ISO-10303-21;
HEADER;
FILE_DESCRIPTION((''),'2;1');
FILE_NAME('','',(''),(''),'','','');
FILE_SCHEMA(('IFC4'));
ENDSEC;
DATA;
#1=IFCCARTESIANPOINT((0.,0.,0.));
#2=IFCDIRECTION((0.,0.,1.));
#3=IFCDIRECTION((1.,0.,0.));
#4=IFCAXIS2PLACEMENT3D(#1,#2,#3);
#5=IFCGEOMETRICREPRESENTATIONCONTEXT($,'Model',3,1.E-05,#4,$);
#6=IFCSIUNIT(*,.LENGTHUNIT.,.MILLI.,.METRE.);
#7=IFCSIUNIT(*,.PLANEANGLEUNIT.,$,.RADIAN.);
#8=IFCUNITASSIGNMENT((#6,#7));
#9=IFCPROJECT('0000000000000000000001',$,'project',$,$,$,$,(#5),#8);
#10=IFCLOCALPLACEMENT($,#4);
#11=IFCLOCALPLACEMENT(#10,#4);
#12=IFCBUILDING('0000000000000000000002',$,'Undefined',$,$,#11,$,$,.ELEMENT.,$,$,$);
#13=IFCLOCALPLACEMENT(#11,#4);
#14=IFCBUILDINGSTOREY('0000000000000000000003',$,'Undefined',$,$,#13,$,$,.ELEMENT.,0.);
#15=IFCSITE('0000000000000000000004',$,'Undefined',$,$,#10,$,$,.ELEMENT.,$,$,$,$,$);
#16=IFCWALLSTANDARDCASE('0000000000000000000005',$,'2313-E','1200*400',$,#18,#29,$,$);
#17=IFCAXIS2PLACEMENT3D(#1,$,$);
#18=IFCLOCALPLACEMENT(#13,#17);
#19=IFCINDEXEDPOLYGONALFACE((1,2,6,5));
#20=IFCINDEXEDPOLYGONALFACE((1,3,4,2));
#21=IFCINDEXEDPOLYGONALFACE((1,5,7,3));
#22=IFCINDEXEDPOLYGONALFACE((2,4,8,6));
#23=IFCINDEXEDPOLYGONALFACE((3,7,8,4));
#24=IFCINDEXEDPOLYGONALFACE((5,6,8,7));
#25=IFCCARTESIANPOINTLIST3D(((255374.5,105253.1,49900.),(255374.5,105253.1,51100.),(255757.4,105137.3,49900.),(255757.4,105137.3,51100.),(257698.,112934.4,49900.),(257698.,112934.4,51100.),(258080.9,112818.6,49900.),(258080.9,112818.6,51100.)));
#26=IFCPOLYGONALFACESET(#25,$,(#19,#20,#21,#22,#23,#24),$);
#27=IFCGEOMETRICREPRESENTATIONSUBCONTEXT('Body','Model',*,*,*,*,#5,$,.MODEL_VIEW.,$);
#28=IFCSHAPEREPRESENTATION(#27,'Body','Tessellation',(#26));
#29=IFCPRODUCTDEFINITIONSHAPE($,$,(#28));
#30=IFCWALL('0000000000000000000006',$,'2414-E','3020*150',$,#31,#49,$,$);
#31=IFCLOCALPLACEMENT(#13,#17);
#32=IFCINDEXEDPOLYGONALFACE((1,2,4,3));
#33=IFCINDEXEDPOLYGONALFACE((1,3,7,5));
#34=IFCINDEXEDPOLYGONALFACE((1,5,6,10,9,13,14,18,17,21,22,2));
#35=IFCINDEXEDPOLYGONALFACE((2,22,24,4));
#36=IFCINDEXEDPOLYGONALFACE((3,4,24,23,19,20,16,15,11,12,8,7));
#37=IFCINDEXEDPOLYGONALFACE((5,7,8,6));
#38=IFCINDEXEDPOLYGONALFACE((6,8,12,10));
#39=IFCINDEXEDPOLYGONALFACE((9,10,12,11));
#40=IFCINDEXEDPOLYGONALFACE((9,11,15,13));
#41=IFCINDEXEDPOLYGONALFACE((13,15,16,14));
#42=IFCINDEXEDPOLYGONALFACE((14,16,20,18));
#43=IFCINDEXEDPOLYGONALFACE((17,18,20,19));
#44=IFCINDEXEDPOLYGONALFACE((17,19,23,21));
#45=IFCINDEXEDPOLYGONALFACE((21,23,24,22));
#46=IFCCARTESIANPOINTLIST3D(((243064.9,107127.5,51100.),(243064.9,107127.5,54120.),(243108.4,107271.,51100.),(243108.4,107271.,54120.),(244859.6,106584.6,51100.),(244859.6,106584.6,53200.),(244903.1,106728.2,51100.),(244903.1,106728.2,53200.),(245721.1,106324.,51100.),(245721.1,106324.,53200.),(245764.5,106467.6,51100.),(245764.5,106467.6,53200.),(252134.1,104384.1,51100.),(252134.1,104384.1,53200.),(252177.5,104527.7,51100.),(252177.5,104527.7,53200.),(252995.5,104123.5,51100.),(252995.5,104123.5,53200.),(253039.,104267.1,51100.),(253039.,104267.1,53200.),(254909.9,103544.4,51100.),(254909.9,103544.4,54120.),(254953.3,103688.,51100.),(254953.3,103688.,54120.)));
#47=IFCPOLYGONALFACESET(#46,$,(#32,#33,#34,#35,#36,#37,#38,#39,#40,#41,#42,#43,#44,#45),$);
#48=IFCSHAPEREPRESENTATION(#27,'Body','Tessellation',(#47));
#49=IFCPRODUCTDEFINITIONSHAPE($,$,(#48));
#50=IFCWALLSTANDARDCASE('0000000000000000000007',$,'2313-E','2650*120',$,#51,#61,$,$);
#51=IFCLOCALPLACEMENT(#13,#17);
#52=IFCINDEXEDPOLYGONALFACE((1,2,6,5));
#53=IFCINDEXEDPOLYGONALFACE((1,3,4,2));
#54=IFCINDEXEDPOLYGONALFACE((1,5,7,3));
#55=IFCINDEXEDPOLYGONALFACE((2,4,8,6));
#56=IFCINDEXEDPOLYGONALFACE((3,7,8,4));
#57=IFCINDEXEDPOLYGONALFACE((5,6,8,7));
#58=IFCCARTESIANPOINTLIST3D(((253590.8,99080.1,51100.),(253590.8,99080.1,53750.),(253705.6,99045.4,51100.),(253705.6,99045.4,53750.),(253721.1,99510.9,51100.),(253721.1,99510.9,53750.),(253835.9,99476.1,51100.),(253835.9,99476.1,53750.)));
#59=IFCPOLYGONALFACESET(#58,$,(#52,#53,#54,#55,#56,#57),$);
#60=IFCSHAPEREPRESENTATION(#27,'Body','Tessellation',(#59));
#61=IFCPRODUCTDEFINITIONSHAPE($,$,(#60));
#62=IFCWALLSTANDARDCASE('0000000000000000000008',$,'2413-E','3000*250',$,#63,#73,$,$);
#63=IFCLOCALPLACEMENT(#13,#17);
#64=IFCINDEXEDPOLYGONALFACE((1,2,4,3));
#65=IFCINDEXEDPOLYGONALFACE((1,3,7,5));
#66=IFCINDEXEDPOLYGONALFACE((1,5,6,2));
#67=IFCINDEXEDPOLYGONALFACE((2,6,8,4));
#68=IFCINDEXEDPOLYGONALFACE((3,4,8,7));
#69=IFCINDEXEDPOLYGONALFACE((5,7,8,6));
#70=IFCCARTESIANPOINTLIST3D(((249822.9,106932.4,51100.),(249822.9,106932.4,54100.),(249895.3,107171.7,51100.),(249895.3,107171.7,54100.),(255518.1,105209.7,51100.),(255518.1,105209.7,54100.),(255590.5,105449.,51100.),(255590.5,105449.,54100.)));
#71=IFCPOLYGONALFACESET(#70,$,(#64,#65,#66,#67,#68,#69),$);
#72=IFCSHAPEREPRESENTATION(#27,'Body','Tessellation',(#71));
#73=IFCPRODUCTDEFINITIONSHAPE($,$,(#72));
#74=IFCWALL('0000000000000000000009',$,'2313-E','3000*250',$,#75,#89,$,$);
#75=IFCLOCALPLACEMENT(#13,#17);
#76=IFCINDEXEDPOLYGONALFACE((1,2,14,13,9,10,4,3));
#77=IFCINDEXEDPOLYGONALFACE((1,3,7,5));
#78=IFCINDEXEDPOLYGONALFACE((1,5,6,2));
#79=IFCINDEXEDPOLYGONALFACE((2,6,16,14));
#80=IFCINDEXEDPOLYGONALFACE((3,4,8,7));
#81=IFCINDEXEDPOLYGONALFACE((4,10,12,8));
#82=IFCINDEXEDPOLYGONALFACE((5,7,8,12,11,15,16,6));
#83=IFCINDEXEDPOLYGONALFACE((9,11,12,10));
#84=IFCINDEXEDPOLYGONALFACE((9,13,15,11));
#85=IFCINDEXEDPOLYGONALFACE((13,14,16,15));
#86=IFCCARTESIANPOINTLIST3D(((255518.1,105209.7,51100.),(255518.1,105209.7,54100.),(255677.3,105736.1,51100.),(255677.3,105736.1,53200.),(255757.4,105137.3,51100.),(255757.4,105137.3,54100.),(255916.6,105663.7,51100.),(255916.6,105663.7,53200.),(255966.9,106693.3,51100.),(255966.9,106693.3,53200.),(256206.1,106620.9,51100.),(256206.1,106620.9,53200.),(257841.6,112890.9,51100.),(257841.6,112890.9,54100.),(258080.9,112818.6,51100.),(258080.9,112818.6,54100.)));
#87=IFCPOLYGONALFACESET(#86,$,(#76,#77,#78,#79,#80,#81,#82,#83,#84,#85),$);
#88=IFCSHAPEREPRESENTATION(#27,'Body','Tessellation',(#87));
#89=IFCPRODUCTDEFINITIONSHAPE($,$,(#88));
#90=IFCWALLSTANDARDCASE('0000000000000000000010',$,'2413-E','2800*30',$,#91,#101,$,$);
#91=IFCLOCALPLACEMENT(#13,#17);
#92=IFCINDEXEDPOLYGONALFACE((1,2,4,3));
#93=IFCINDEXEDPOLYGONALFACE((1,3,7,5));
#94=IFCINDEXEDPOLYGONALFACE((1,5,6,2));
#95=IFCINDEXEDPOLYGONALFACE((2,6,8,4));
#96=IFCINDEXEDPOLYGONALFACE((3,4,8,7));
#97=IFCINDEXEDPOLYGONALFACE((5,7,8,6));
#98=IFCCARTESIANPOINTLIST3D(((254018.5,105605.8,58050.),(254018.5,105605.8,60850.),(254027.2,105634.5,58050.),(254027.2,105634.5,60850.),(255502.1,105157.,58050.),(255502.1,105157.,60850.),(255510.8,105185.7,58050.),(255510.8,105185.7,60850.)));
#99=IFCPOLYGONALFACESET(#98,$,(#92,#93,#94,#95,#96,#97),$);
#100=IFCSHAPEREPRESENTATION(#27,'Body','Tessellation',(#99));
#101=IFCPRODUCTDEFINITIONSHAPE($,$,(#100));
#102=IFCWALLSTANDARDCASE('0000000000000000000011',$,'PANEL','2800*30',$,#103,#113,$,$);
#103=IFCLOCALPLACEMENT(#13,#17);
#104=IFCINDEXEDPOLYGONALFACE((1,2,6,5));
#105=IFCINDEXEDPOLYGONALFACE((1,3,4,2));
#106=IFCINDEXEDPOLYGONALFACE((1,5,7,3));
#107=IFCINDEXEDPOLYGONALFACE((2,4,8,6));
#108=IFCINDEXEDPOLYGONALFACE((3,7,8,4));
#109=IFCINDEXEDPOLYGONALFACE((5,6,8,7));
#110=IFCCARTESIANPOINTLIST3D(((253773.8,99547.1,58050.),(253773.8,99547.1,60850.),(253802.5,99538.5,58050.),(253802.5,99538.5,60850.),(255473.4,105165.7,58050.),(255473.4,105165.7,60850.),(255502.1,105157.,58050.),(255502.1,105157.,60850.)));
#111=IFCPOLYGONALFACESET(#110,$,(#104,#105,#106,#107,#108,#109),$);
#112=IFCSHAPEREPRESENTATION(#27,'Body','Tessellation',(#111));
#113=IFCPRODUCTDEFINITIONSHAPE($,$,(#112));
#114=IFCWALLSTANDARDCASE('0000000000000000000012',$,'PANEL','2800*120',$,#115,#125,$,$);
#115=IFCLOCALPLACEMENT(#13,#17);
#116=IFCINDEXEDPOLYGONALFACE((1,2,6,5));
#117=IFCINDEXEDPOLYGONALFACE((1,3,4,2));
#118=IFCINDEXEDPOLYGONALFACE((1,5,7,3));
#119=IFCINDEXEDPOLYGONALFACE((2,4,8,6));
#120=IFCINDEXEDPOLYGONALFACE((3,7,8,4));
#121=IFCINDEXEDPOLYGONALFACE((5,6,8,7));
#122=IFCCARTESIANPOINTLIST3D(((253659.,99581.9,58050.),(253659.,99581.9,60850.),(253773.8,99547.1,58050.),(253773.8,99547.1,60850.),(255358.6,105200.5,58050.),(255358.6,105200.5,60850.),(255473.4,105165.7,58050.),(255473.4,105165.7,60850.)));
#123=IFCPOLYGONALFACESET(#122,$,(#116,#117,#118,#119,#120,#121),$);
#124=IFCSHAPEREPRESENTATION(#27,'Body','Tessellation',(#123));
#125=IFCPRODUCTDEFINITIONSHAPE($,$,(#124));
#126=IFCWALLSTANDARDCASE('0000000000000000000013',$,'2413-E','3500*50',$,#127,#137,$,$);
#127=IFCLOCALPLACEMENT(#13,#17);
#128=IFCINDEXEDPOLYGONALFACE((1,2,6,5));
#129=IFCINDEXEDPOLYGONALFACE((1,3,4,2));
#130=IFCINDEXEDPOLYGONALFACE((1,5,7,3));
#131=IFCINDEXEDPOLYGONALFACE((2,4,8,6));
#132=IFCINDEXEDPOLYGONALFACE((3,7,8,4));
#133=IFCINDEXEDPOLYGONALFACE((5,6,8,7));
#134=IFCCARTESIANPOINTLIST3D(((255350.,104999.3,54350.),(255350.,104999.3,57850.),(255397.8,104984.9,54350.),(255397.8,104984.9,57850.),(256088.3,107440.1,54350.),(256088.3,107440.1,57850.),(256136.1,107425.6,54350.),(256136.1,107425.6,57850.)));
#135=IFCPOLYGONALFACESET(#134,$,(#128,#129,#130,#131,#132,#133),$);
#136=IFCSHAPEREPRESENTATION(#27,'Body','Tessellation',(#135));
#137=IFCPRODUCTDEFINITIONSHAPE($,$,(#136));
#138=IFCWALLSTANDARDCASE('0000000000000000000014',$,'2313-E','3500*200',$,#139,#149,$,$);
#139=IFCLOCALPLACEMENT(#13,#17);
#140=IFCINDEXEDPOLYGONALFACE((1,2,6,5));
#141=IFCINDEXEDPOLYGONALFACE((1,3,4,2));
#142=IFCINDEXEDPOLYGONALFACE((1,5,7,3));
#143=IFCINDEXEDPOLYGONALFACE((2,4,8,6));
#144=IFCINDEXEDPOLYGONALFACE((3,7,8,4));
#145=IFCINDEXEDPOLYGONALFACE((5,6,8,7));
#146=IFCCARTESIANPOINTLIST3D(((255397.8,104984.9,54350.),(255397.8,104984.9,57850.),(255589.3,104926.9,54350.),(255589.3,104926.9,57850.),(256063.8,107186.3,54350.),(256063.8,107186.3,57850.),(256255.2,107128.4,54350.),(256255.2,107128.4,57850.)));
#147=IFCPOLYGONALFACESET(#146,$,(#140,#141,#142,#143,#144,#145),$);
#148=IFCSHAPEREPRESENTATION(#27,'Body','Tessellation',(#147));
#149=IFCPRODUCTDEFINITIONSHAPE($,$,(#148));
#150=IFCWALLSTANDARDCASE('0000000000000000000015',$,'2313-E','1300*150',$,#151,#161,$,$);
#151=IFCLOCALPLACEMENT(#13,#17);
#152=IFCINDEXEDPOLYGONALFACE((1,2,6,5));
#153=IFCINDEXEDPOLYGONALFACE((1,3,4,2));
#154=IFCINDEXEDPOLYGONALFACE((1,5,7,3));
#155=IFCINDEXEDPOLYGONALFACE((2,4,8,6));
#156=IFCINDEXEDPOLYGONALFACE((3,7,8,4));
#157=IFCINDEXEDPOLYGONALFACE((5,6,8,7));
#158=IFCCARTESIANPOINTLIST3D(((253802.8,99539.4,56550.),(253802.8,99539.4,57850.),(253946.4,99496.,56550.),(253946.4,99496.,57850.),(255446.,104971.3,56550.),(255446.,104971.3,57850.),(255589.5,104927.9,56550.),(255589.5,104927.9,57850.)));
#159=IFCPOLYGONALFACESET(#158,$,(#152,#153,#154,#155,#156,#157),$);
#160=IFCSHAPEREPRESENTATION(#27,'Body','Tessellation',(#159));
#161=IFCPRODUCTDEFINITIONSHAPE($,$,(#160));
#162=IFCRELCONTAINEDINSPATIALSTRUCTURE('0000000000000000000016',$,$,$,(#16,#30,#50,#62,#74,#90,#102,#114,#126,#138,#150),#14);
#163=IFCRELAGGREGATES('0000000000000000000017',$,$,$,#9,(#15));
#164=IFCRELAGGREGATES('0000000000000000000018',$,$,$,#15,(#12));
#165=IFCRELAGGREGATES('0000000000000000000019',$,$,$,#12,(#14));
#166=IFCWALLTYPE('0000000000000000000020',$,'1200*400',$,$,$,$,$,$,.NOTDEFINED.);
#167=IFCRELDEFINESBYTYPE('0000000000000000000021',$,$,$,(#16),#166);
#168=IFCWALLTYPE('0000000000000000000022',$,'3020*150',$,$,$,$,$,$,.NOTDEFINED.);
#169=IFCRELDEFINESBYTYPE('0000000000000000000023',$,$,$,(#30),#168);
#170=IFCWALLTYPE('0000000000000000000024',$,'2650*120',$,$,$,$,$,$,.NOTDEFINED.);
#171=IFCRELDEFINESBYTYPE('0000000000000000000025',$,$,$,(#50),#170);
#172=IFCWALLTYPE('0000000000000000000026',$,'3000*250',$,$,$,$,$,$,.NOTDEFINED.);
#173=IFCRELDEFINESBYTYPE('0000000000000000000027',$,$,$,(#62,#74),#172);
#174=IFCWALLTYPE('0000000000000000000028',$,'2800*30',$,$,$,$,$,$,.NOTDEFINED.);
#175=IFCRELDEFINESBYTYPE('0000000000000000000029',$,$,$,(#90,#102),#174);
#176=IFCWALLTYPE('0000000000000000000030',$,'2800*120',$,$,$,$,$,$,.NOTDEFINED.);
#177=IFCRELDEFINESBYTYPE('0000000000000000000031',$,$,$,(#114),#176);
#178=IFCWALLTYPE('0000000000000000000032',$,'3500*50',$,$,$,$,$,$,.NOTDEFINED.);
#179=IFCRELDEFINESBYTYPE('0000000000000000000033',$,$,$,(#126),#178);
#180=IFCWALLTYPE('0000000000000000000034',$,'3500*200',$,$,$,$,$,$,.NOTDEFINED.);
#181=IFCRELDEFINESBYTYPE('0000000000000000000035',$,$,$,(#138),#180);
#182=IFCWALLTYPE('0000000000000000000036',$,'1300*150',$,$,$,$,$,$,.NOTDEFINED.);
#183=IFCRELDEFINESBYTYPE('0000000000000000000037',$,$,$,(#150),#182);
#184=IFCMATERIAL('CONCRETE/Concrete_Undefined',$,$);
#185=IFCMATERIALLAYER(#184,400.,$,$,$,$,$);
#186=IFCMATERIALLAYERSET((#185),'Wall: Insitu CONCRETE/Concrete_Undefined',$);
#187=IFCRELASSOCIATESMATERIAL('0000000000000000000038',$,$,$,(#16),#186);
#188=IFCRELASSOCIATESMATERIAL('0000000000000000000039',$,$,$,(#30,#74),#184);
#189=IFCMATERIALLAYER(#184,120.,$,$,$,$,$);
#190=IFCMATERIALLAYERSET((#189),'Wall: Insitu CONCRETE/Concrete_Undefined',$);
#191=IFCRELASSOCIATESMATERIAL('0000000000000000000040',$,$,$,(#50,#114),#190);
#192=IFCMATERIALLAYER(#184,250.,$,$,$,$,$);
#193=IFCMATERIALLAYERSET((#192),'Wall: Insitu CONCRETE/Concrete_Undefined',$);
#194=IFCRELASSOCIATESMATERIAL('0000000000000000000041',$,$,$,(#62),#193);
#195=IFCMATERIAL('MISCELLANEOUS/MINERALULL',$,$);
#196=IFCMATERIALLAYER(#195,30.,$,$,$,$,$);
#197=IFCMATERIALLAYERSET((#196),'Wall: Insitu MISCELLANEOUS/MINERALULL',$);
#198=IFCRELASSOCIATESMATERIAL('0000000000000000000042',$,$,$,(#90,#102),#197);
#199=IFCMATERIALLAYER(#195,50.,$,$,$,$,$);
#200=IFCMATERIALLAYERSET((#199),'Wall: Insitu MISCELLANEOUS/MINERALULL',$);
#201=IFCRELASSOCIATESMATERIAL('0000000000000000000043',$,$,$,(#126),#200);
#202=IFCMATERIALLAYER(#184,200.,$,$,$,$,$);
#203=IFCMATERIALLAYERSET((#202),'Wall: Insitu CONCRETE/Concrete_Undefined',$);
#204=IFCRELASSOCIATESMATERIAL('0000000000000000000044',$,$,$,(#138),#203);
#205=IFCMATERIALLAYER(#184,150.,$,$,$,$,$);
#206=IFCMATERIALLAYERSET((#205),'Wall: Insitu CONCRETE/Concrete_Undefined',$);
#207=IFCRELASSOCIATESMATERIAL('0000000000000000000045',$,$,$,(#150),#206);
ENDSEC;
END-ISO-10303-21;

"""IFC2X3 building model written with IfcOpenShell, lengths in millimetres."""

from ifc_helpers import new_model, si_unit, frame, frame_2d, origin_with_axes, place, context, subcontext, project, spatial, rectangle, extrude, boolean, material, layer, layer_set, layer_usage, type_object, element, save


model = new_model("IFC2X3")

# Units and contexts
model_context = context("Model", 3, precision=1e-05, world=origin_with_axes())
body_context = subcontext(model_context, "Body", "Model", "MODEL_VIEW")
ifc_project = project(units=[si_unit("LENGTHUNIT", "METRE", prefix="MILLI"), si_unit("PLANEANGLEUNIT", "RADIAN")], contexts=[model_context])

# Site, building, storey
site_placement = place(None, origin_with_axes())
site = spatial("IfcSite", under=ifc_project, at=site_placement, Name="Undefined", CompositionType="ELEMENT")
building_placement = place(site_placement, origin_with_axes())
building = spatial("IfcBuilding", under=site, at=building_placement, Name="Undefined", CompositionType="ELEMENT")
storey_placement = place(building_placement, origin_with_axes())
storey = spatial("IfcBuildingStorey", under=building, at=storey_placement, Name="Undefined", CompositionType="ELEMENT", Elevation=0.0)

# Shared definitions
ifc_material_1 = material(Name="CONCRETE/Concrete_Undefined")

# Walls
ifc_layer_1 = layer(ifc_material_1, 250.0)
ifc_layer_set_1 = layer_set([ifc_layer_1], Name="Wall: Insitu CONCRETE/Concrete_Undefined")
ifc_layer_2 = layer(ifc_material_1, 400.0)
ifc_layer_set_2 = layer_set([ifc_layer_2], Name="Wall: Insitu CONCRETE/Concrete_Undefined")
ifc_layer_usage_1 = layer_usage(ifc_layer_set_2, "AXIS2", "POSITIVE", -200.0)
wall_type_1 = type_object("IfcWallType", Name="1200*400", PredefinedType="NOTDEFINED")
wall_1_placement = place(storey_placement, frame((255565.9, 105195.2, 49900.0), z_axis=(0.0, 0.0, 1.0), x_axis=(0.289538, 0.957166, 0.0)))
element("IfcWallStandardCase", 1, at=wall_1_placement, inside=storey, type_object=wall_type_1, material=ifc_layer_usage_1, Name="2313-E", Description="1200*400", context=body_context, shape_type="SweptSolid", body=[
    extrude(rectangle(XDim=8025.0, YDim=400.0, at=frame_2d((0.0, 4012.5), x_axis=(0.0, -1.0))), frame((0.0, 0.0, 0.0), z_axis=(0.0, 0.0, 1.0), x_axis=(0.0, -1.0, 0.0)), (0.0, 0.0, 1.0), 1200.0),
])
wall_type_2 = type_object("IfcWallType", Name="3020*150", PredefinedType="NOTDEFINED")
wall_2_placement = place(storey_placement, frame((254931.6, 103616.2, 51100.0), z_axis=(0.0, 0.0, 1.0), x_axis=(-0.957166, 0.289539, 0.0)))
element("IfcWall", 2, at=wall_2_placement, inside=storey, type_object=wall_type_2, material=ifc_material_1, Name="2414-E", Description="3020*150", context=body_context, shape_type="CSG", body=[
    boolean("DIFFERENCE", boolean("DIFFERENCE", extrude(rectangle(XDim=12375.0, YDim=150.0, at=frame_2d((0.0, 6187.5), x_axis=(0.0, -1.0))), frame((0.0, 0.0, 0.0), z_axis=(0.0, 0.0, 1.0), x_axis=(0.0, -1.0, 0.0)), (0.0, 0.0, 1.0), 3020.0), extrude(rectangle(XDim=900.0, YDim=150.0, at=frame_2d((0.0, 450.0), x_axis=(0.0, -1.0))), frame((2900.0, 0.0, 0.0), z_axis=(0.0, 0.0, 1.0), x_axis=(0.000003, 1.0, 0.0)), (0.0, 0.0, 1.0), 2100.0)), extrude(rectangle(XDim=900.0, YDim=150.0, at=frame_2d((0.0, 450.0), x_axis=(0.0, -1.0))), frame((10500.0, 0.0, 0.0), z_axis=(0.0, 0.0, 1.0), x_axis=(0.000003, 1.0, 0.0)), (0.0, 0.0, 1.0), 2100.0)),
])
ifc_layer_3 = layer(ifc_material_1, 120.0)
ifc_layer_set_3 = layer_set([ifc_layer_3], Name="Wall: Insitu CONCRETE/Concrete_Undefined")
ifc_layer_usage_2 = layer_usage(ifc_layer_set_3, "AXIS2", "POSITIVE", -60.0)
wall_type_3 = type_object("IfcWallType", Name="2650*120", PredefinedType="NOTDEFINED")
wall_3_placement = place(storey_placement, frame((253778.5, 99493.5, 51100.0), z_axis=(0.0, 0.0, 1.0), x_axis=(-0.289534, -0.957168, 0.0)))
element("IfcWallStandardCase", 3, at=wall_3_placement, inside=storey, type_object=wall_type_3, material=ifc_layer_usage_2, Name="2313-E", Description="2650*120", context=body_context, shape_type="SweptSolid", body=[
    extrude(rectangle(XDim=450.0, YDim=120.0, at=frame_2d((0.0, 225.0), x_axis=(0.0, -1.0))), frame((0.0, 0.0, 0.0), z_axis=(0.0, 0.0, 1.0), x_axis=(0.0, -1.0, 0.0)), (0.0, 0.0, 1.0), 2650.0),
])
ifc_material_2 = material(Name="MISCELLANEOUS/MINERALULL")
ifc_layer_usage_3 = layer_usage(ifc_layer_set_1, "AXIS2", "POSITIVE", -125.0)
wall_type_4 = type_object("IfcWallType", Name="3000*250", PredefinedType="NOTDEFINED")
wall_4_placement = place(storey_placement, frame((249859.1, 107052.1, 51100.0), z_axis=(0.0, 0.0, 1.0), x_axis=(0.957167, -0.289537, 0.0)))
element("IfcWallStandardCase", 4, at=wall_4_placement, inside=storey, type_object=wall_type_4, material=ifc_layer_usage_3, Name="2413-E", Description="3000*250", context=body_context, shape_type="SweptSolid", body=[
    extrude(rectangle(XDim=5950.0, YDim=250.0, at=frame_2d((0.0, 2975.0), x_axis=(0.0, -1.0))), frame((0.0, 0.0, 0.0), z_axis=(0.0, 0.0, 1.0), x_axis=(0.0, -1.0, 0.0)), (0.0, 0.0, 1.0), 3000.0),
])
wall_5_placement = place(storey_placement, frame((255637.7, 105173.5, 51100.0), z_axis=(0.0, 0.0, 1.0), x_axis=(0.289538, 0.957166, 0.0)))
element("IfcWall", 5, at=wall_5_placement, inside=storey, type_object=wall_type_4, material=ifc_material_1, Name="2313-E", Description="3000*250", context=body_context, shape_type="CSG", body=[
    boolean("DIFFERENCE", extrude(rectangle(XDim=8025.0, YDim=250.0, at=frame_2d((0.0, 4012.5), x_axis=(0.0, -1.0))), frame((0.0, 0.0, 0.0), z_axis=(0.0, 0.0, 1.0), x_axis=(0.0, -1.0, 0.0)), (0.0, 0.0, 1.0), 3000.0), extrude(rectangle(XDim=1000.0, YDim=250.0, at=frame_2d((0.0, 500.0), x_axis=(0.0, -1.0))), frame((1550.0, 0.0, 0.0), z_axis=(0.0, 0.0, 1.0), x_axis=(0.000003, 1.0, 0.0)), (0.0, 0.0, 1.0), 2100.0)),
])
ifc_layer_4 = layer(ifc_material_2, 30.0)
ifc_layer_set_4 = layer_set([ifc_layer_4], Name="Wall: Insitu MISCELLANEOUS/MINERALULL")
ifc_layer_usage_4 = layer_usage(ifc_layer_set_4, "AXIS2", "POSITIVE", -15.0)
wall_type_5 = type_object("IfcWallType", Name="2800*30", PredefinedType="NOTDEFINED")
wall_6_placement = place(storey_placement, frame((254022.9, 105620.2, 58050.0), z_axis=(0.0, 0.0, 1.0), x_axis=(0.957168, -0.289533, 0.0)))
element("IfcWallStandardCase", 6, at=wall_6_placement, inside=storey, type_object=wall_type_5, material=ifc_layer_usage_4, Name="2413-E", Description="2800*30", context=body_context, shape_type="SweptSolid", body=[
    extrude(rectangle(XDim=1550.0, YDim=30.0, at=frame_2d((0.0, 775.0), x_axis=(0.0, -1.0))), frame((0.0, 0.0, 0.0), z_axis=(0.0, 0.0, 1.0), x_axis=(0.0, -1.0, 0.0)), (0.0, 0.0, 1.0), 2800.0),
])
ifc_layer_usage_5 = layer_usage(ifc_layer_set_4, "AXIS2", "POSITIVE", -15.0)
wall_7_placement = place(storey_placement, frame((255487.8, 105161.4, 58050.0), z_axis=(0.0, 0.0, 1.0), x_axis=(-0.289539, -0.957166, 0.0)))
element("IfcWallStandardCase", 7, at=wall_7_placement, inside=storey, type_object=wall_type_5, material=ifc_layer_usage_5, Name="PANEL", Description="2800*30", context=body_context, shape_type="SweptSolid", body=[
    extrude(rectangle(XDim=5870.0, YDim=30.0, at=frame_2d((0.0, 2935.0), x_axis=(0.0, -1.0))), frame((0.0, 0.0, 0.0), z_axis=(0.0, 0.0, 1.0), x_axis=(0.0, -1.0, 0.0)), (0.0, 0.0, 1.0), 2800.0),
])
ifc_layer_usage_6 = layer_usage(ifc_layer_set_3, "AXIS2", "POSITIVE", -60.0)
wall_type_6 = type_object("IfcWallType", Name="2800*120", PredefinedType="NOTDEFINED")
wall_8_placement = place(storey_placement, frame((255416.0, 105183.1, 58050.0), z_axis=(0.0, 0.0, 1.0), x_axis=(-0.289539, -0.957166, 0.0)))
element("IfcWallStandardCase", 8, at=wall_8_placement, inside=storey, type_object=wall_type_6, material=ifc_layer_usage_6, Name="PANEL", Description="2800*120", context=body_context, shape_type="SweptSolid", body=[
    extrude(rectangle(XDim=5870.0, YDim=120.0, at=frame_2d((0.0, 2935.0), x_axis=(0.0, -1.0))), frame((0.0, 0.0, 0.0), z_axis=(0.0, 0.0, 1.0), x_axis=(0.0, -1.0, 0.0)), (0.0, 0.0, 1.0), 2800.0),
])
ifc_layer_5 = layer(ifc_material_2, 50.0)
ifc_layer_set_5 = layer_set([ifc_layer_5], Name="Wall: Insitu MISCELLANEOUS/MINERALULL")
ifc_layer_usage_7 = layer_usage(ifc_layer_set_5, "AXIS2", "POSITIVE", -25.0)
wall_type_7 = type_object("IfcWallType", Name="3500*50", PredefinedType="NOTDEFINED")
wall_9_placement = place(storey_placement, frame((255373.9, 104992.1, 54350.0), z_axis=(0.0, 0.0, 1.0), x_axis=(0.289536, 0.957167, 0.0)))
element("IfcWallStandardCase", 9, at=wall_9_placement, inside=storey, type_object=wall_type_7, material=ifc_layer_usage_7, Name="2413-E", Description="3500*50", context=body_context, shape_type="SweptSolid", body=[
    extrude(rectangle(XDim=2550.0, YDim=50.0, at=frame_2d((0.0, 1275.0), x_axis=(0.0, -1.0))), frame((0.0, 0.0, 0.0), z_axis=(0.0, 0.0, 1.0), x_axis=(0.0, -1.0, 0.0)), (0.0, 0.0, 1.0), 3500.0),
])
ifc_layer_6 = layer(ifc_material_1, 200.0)
ifc_layer_set_6 = layer_set([ifc_layer_6], Name="Wall: Insitu CONCRETE/Concrete_Undefined")
ifc_layer_usage_8 = layer_usage(ifc_layer_set_6, "AXIS2", "POSITIVE", -100.0)
wall_type_8 = type_object("IfcWallType", Name="3500*200", PredefinedType="NOTDEFINED")
wall_10_placement = place(storey_placement, frame((255493.5, 104955.9, 54350.0), z_axis=(0.0, 0.0, 1.0), x_axis=(0.289537, 0.957167, 0.0)))
element("IfcWallStandardCase", 10, at=wall_10_placement, inside=storey, type_object=wall_type_8, material=ifc_layer_usage_8, Name="2313-E", Description="3500*200", context=body_context, shape_type="SweptSolid", body=[
    extrude(rectangle(XDim=2300.0, YDim=200.0, at=frame_2d((0.0, 1150.0), x_axis=(0.0, -1.0))), frame((0.0, 0.0, 0.0), z_axis=(0.0, 0.0, 1.0), x_axis=(0.0, -1.0, 0.0)), (0.0, 0.0, 1.0), 3500.0),
])
ifc_layer_7 = layer(ifc_material_1, 150.0)
ifc_layer_set_7 = layer_set([ifc_layer_7], Name="Wall: Insitu CONCRETE/Concrete_Undefined")
ifc_layer_usage_9 = layer_usage(ifc_layer_set_7, "AXIS2", "POSITIVE", -75.0)
wall_type_9 = type_object("IfcWallType", Name="1300*150", PredefinedType="NOTDEFINED")
wall_11_placement = place(storey_placement, frame((255517.8, 104949.6, 56550.0), z_axis=(0.0, 0.0, 1.0), x_axis=(-0.289538, -0.957167, 0.0)))
element("IfcWallStandardCase", 11, at=wall_11_placement, inside=storey, type_object=wall_type_9, material=ifc_layer_usage_9, Name="2313-E", Description="1300*150", context=body_context, shape_type="SweptSolid", body=[
    extrude(rectangle(XDim=5675.0, YDim=150.0, at=frame_2d((0.0, 2837.5), x_axis=(0.0, -1.0))), frame((0.0, 0.0, 0.0), z_axis=(0.0, 0.0, 1.0), x_axis=(0.0, -1.0, 0.0)), (0.0, 0.0, 1.0), 1300.0),
])

save(model, "model.ifc")
